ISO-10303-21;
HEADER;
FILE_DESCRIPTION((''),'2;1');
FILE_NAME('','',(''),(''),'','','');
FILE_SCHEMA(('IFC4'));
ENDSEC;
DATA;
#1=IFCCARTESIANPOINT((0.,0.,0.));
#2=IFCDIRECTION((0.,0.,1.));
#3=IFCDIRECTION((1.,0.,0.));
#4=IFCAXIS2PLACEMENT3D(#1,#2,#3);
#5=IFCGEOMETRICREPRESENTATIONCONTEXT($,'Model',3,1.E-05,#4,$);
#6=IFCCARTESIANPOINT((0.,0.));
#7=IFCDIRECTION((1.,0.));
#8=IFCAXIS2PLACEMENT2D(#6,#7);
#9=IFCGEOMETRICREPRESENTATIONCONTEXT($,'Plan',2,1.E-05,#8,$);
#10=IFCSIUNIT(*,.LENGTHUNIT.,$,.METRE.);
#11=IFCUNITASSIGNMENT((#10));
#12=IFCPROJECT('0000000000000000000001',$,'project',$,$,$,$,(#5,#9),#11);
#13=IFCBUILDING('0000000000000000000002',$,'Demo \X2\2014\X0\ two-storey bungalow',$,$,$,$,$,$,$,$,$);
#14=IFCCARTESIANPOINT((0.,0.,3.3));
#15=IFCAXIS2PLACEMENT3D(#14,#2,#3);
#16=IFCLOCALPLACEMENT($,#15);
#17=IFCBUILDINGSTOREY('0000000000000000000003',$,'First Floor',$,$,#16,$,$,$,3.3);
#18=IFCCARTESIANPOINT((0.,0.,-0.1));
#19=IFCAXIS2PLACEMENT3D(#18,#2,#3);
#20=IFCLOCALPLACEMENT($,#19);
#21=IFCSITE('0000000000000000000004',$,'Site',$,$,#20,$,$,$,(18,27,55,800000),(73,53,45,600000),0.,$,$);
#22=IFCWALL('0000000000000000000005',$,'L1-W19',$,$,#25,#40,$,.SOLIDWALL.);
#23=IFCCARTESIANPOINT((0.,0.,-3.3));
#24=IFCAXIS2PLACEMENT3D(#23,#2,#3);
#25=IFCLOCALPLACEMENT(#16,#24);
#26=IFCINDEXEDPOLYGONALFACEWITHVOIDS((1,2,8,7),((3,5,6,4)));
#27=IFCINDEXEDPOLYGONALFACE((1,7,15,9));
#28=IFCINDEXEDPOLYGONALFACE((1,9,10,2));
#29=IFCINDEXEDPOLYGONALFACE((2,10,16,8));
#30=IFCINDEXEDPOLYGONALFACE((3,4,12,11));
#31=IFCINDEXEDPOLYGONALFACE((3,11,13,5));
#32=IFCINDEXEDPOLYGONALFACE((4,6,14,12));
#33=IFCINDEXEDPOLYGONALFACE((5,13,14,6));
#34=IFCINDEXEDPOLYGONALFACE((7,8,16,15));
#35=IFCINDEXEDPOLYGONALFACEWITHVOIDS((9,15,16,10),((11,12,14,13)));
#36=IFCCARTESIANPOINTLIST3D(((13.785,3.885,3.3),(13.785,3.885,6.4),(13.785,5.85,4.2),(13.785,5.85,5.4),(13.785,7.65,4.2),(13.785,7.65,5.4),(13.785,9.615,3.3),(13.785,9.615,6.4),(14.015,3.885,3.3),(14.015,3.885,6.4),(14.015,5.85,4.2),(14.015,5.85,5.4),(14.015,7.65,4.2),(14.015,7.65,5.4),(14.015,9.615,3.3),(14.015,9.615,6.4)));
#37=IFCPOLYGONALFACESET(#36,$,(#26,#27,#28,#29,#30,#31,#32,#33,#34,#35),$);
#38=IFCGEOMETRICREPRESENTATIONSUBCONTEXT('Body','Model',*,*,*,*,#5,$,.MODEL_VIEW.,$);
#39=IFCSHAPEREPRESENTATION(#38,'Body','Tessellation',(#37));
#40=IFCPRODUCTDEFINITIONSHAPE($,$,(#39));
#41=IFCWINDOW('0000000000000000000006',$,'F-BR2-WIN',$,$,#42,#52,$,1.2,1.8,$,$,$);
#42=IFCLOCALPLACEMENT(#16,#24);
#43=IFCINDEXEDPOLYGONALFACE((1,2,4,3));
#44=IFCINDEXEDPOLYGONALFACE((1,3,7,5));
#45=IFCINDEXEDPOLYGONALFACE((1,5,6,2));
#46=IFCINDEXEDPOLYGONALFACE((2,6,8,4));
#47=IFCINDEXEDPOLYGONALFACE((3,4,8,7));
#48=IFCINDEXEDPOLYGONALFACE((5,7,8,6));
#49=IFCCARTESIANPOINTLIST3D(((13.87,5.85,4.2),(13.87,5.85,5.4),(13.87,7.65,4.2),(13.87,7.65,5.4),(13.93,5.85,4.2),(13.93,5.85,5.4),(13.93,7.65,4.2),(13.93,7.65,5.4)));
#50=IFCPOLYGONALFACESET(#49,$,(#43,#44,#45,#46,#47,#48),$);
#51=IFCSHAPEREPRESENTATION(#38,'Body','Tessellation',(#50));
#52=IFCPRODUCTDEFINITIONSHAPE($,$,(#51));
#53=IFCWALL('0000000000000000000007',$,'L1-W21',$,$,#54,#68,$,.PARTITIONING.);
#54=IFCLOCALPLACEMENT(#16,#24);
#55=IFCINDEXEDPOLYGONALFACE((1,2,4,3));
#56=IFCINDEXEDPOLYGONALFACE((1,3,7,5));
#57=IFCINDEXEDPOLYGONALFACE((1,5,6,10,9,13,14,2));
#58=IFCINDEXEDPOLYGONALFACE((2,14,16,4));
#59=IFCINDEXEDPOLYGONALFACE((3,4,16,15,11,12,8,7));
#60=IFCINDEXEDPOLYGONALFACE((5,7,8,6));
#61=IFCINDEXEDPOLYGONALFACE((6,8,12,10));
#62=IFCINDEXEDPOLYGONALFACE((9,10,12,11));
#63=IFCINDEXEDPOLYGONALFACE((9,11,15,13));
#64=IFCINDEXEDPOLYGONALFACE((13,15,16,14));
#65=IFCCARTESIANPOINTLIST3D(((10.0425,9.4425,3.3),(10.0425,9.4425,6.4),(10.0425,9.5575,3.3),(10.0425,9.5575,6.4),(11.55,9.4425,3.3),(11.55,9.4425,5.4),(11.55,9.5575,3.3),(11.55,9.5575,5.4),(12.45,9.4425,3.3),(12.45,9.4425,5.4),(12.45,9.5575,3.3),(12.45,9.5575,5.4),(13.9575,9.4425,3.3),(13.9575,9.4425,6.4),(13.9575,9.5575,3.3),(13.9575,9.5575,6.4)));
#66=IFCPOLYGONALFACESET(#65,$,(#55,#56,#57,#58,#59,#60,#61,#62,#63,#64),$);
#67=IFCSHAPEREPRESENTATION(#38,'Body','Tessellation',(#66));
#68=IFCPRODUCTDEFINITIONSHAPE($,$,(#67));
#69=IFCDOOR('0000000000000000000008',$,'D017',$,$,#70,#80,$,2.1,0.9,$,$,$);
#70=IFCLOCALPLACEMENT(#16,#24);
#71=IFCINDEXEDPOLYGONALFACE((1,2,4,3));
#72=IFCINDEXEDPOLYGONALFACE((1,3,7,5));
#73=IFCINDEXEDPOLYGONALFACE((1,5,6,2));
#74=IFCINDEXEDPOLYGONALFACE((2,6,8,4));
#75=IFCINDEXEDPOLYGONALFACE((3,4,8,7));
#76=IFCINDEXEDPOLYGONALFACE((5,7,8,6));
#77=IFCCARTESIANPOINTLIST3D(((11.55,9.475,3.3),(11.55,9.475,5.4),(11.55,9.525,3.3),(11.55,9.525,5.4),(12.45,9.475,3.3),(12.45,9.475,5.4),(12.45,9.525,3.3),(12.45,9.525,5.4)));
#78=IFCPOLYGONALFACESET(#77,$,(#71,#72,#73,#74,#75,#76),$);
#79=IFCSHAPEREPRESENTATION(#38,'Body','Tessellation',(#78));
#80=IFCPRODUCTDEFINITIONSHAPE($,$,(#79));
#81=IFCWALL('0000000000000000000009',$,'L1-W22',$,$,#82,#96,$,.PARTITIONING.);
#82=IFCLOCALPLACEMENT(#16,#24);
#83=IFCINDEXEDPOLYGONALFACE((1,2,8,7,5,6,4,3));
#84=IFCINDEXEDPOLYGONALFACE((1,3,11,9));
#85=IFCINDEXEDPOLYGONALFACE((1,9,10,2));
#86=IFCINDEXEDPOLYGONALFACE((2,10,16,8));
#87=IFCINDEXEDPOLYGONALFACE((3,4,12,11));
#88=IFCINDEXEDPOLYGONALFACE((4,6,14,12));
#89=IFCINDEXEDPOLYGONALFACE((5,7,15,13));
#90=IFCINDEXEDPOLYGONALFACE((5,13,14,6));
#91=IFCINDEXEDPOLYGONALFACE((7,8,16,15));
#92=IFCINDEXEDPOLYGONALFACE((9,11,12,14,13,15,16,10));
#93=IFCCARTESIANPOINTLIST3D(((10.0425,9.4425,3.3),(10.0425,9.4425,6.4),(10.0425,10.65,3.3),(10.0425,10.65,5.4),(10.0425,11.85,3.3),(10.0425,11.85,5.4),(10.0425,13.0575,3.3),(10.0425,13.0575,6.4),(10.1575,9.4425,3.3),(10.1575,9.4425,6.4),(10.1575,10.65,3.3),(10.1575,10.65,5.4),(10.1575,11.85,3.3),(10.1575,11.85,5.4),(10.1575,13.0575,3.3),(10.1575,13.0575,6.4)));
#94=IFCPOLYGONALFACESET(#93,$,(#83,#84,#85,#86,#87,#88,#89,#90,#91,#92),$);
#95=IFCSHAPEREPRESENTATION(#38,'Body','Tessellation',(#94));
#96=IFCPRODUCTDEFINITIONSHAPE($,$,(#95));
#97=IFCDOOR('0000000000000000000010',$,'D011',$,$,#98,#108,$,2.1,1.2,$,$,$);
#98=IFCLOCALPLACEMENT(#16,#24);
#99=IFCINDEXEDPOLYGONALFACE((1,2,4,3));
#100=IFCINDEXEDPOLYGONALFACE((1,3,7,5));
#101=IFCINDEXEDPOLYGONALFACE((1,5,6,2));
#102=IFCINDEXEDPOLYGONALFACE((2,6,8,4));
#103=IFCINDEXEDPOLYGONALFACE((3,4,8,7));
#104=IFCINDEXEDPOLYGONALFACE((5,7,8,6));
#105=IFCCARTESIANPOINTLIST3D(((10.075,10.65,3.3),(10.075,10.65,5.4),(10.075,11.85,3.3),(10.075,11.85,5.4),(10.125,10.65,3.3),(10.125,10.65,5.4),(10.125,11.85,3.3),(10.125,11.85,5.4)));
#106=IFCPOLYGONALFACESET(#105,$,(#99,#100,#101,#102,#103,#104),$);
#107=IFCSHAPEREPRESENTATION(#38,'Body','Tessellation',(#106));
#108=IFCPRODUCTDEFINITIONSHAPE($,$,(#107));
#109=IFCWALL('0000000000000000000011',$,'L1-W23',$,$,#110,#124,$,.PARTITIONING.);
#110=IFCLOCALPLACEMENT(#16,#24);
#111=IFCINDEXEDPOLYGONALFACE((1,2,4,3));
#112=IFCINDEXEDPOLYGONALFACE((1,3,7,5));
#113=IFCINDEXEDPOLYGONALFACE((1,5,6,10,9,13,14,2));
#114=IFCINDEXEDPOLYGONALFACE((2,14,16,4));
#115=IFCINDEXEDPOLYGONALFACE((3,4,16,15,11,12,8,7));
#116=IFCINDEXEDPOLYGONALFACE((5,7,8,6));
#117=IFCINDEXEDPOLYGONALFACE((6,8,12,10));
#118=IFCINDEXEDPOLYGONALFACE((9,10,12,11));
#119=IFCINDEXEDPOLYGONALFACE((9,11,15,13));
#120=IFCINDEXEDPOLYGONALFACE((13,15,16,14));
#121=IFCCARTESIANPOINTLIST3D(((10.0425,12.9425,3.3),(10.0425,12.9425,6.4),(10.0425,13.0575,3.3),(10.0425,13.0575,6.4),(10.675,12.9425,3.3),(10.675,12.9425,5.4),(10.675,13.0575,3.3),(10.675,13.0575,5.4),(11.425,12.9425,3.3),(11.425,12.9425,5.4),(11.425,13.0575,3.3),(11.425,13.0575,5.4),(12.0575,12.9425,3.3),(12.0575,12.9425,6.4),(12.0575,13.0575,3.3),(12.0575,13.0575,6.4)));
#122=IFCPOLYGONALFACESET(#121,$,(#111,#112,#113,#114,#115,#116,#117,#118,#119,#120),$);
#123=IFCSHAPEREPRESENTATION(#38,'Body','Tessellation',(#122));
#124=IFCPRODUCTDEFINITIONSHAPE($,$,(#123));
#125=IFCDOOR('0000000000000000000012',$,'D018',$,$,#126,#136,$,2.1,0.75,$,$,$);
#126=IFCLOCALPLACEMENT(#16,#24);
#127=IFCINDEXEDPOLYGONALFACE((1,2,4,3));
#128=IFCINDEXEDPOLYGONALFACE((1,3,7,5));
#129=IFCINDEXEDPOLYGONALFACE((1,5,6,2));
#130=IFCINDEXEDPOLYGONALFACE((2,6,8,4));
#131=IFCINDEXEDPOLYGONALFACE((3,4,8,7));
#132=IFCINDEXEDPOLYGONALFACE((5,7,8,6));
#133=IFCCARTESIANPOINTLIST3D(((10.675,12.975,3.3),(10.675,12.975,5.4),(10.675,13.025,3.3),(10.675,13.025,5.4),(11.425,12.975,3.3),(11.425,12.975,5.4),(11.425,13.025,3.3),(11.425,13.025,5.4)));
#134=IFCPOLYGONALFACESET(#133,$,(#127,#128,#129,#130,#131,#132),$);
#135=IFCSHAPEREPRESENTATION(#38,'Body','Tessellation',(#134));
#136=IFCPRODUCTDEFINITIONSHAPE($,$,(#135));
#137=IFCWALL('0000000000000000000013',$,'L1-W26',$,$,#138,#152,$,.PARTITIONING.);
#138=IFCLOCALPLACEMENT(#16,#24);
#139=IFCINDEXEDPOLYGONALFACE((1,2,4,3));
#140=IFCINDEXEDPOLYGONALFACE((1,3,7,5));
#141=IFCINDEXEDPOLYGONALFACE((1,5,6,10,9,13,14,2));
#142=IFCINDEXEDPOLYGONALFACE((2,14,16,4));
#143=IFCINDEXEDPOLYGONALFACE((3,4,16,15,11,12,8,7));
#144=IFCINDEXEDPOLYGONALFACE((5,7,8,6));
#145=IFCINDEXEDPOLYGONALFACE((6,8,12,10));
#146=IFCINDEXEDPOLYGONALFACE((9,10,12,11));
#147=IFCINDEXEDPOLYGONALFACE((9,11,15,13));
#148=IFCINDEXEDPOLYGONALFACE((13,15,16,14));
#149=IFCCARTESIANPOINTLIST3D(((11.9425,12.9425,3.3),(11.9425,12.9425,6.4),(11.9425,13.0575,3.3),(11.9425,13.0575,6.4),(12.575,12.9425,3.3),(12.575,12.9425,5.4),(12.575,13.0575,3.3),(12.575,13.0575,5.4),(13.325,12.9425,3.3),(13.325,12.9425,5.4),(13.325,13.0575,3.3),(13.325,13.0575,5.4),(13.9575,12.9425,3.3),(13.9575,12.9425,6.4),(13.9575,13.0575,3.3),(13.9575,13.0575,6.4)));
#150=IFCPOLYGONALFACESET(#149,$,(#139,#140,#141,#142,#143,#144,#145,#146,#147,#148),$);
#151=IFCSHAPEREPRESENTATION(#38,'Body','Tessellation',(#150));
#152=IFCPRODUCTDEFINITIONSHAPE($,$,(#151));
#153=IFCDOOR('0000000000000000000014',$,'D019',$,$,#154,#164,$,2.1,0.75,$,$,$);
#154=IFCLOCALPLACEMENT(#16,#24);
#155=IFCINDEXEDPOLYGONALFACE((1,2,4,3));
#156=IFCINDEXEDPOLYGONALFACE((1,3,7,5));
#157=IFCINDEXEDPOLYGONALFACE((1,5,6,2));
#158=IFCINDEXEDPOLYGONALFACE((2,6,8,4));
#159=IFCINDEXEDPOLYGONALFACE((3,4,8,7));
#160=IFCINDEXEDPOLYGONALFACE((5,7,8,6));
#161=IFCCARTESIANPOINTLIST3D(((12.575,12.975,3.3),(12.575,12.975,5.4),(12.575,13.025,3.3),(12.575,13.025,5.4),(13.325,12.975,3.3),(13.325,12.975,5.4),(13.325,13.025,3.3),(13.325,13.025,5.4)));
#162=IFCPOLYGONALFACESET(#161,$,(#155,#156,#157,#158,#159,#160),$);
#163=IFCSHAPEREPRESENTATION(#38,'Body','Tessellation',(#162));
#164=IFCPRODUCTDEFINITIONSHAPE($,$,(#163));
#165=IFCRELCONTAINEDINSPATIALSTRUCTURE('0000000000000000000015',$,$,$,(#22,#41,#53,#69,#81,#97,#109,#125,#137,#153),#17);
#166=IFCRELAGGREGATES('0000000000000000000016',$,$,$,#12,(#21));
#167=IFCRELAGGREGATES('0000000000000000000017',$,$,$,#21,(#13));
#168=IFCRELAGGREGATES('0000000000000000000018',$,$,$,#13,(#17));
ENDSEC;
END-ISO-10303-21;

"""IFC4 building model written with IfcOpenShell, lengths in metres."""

from ifc_helpers import new_model, si_unit, frame, origin_with_axes, origin_2d_with_axis, place, context, subcontext, project, spatial, line, indexed_curve, outline, extrude, element, fill, save


model = new_model("IFC4")

# Units and contexts
model_context = context("Model", 3, precision=1e-05, world=origin_with_axes())
plan_context = context("Plan", 2, precision=1e-05, world=origin_2d_with_axis())
body_context = subcontext(model_context, "Body", "Model", "MODEL_VIEW")
ifc_project = project(units=[si_unit("LENGTHUNIT", "METRE")], contexts=[model_context, plan_context])

# Site, building, storey
site_placement = place(None, frame((0.0, 0.0, -0.1), z_axis=(0.0, 0.0, 1.0), x_axis=(1.0, 0.0, 0.0)))
site = spatial("IfcSite", under=ifc_project, at=site_placement, Name="Site", RefLatitude=(18, 27, 55, 800000), RefLongitude=(73, 53, 45, 600000), RefElevation=0.0)
building = spatial("IfcBuilding", under=site, Name="Demo — two-storey bungalow")
storey_placement = place(None, frame((0.0, 0.0, 3.3), z_axis=(0.0, 0.0, 1.0), x_axis=(1.0, 0.0, 0.0)))
storey = spatial("IfcBuildingStorey", under=building, at=storey_placement, Name="First Floor", Elevation=3.3)

# Wall, opening, window
wall_1_placement = place(storey_placement, frame((0.0, 0.0, -3.3), z_axis=(0.0, 0.0, 1.0), x_axis=(1.0, 0.0, 0.0)))
wall_1 = element("IfcWall", 1, at=wall_1_placement, inside=storey, Name="L1-W19", PredefinedType="SOLIDWALL", context=body_context, shape_type="SweptSolid", body=[
    extrude(outline(indexed_curve([(13.785, 3.885), (13.785, 9.615), (14.015, 9.615), (14.015, 3.885)], segments=[line(1, 2, 3, 4, 1)])), frame((0.0, 0.0, 3.3), z_axis=(0.0, 0.0, 1.0), x_axis=(1.0, 0.0, 0.0)), (0.0, 0.0, 1.0), 3.1),
])
opening_1_placement = place(wall_1_placement, origin_with_axes())
opening_1 = element("IfcOpeningElement", 2, at=opening_1_placement, cuts=wall_1, context=body_context, shape_type="SweptSolid", body=[
    extrude(outline(indexed_curve([(13.735, 5.85), (13.735, 7.65), (14.065, 7.65), (14.065, 5.85)], segments=[line(1, 2, 3, 4, 1)])), frame((0.0, 0.0, 4.2), z_axis=(0.0, 0.0, 1.0), x_axis=(1.0, 0.0, 0.0)), (0.0, 0.0, 1.0), 1.2),
])
window_1_placement = place(storey_placement, frame((0.0, 0.0, -3.3), z_axis=(0.0, 0.0, 1.0), x_axis=(1.0, 0.0, 0.0)))
window_1 = element("IfcWindow", 3, at=window_1_placement, inside=storey, Name="F-BR2-WIN", OverallHeight=1.2, OverallWidth=1.8, context=body_context, shape_type="SweptSolid", body=[
    extrude(outline(indexed_curve([(13.87, 5.85), (13.87, 7.65), (13.93, 7.65), (13.93, 5.85)], segments=[line(1, 2, 3, 4, 1)])), frame((0.0, 0.0, 4.2), z_axis=(0.0, 0.0, 1.0), x_axis=(1.0, 0.0, 0.0)), (0.0, 0.0, 1.0), 1.2),
])
fill(opening_1, window_1)

# Walls, openings, doors
wall_2_placement = place(storey_placement, frame((0.0, 0.0, -3.3), z_axis=(0.0, 0.0, 1.0), x_axis=(1.0, 0.0, 0.0)))
wall_2 = element("IfcWall", 4, at=wall_2_placement, inside=storey, Name="L1-W21", PredefinedType="PARTITIONING", context=body_context, shape_type="SweptSolid", body=[
    extrude(outline(indexed_curve([(13.9575, 9.4425), (10.0425, 9.4425), (10.0425, 9.5575), (13.9575, 9.5575)], segments=[line(1, 2, 3, 4, 1)])), frame((0.0, 0.0, 3.3), z_axis=(0.0, 0.0, 1.0), x_axis=(1.0, 0.0, 0.0)), (0.0, 0.0, 1.0), 3.1),
])
opening_2_placement = place(wall_2_placement, origin_with_axes())
opening_2 = element("IfcOpeningElement", 5, at=opening_2_placement, cuts=wall_2, context=body_context, shape_type="SweptSolid", body=[
    extrude(outline(indexed_curve([(12.45, 9.3925), (11.55, 9.3925), (11.55, 9.6075), (12.45, 9.6075)], segments=[line(1, 2, 3, 4, 1)])), frame((0.0, 0.0, 3.3), z_axis=(0.0, 0.0, 1.0), x_axis=(1.0, 0.0, 0.0)), (0.0, 0.0, 1.0), 2.1),
])
door_1_placement = place(storey_placement, frame((0.0, 0.0, -3.3), z_axis=(0.0, 0.0, 1.0), x_axis=(1.0, 0.0, 0.0)))
door_1 = element("IfcDoor", 6, at=door_1_placement, inside=storey, Name="D017", OverallHeight=2.1, OverallWidth=0.9, context=body_context, shape_type="SweptSolid", body=[
    extrude(outline(indexed_curve([(12.45, 9.475), (11.55, 9.475), (11.55, 9.525), (12.45, 9.525)], segments=[line(1, 2, 3, 4, 1)])), frame((0.0, 0.0, 3.3), z_axis=(0.0, 0.0, 1.0), x_axis=(1.0, 0.0, 0.0)), (0.0, 0.0, 1.0), 2.1),
])
fill(opening_2, door_1)
wall_3_placement = place(storey_placement, frame((0.0, 0.0, -3.3), z_axis=(0.0, 0.0, 1.0), x_axis=(1.0, 0.0, 0.0)))
wall_3 = element("IfcWall", 7, at=wall_3_placement, inside=storey, Name="L1-W22", PredefinedType="PARTITIONING", context=body_context, shape_type="SweptSolid", body=[
    extrude(outline(indexed_curve([(10.0425, 9.4425), (10.0425, 13.0575), (10.1575, 13.0575), (10.1575, 9.4425)], segments=[line(1, 2, 3, 4, 1)])), frame((0.0, 0.0, 3.3), z_axis=(0.0, 0.0, 1.0), x_axis=(1.0, 0.0, 0.0)), (0.0, 0.0, 1.0), 3.1),
])
opening_3_placement = place(wall_3_placement, origin_with_axes())
opening_3 = element("IfcOpeningElement", 8, at=opening_3_placement, cuts=wall_3, context=body_context, shape_type="SweptSolid", body=[
    extrude(outline(indexed_curve([(9.9925, 10.65), (9.9925, 11.85), (10.2075, 11.85), (10.2075, 10.65)], segments=[line(1, 2, 3, 4, 1)])), frame((0.0, 0.0, 3.3), z_axis=(0.0, 0.0, 1.0), x_axis=(1.0, 0.0, 0.0)), (0.0, 0.0, 1.0), 2.1),
])
door_2_placement = place(storey_placement, frame((0.0, 0.0, -3.3), z_axis=(0.0, 0.0, 1.0), x_axis=(1.0, 0.0, 0.0)))
door_2 = element("IfcDoor", 9, at=door_2_placement, inside=storey, Name="D011", OverallHeight=2.1, OverallWidth=1.2, context=body_context, shape_type="SweptSolid", body=[
    extrude(outline(indexed_curve([(10.075, 10.65), (10.075, 11.85), (10.125, 11.85), (10.125, 10.65)], segments=[line(1, 2, 3, 4, 1)])), frame((0.0, 0.0, 3.3), z_axis=(0.0, 0.0, 1.0), x_axis=(1.0, 0.0, 0.0)), (0.0, 0.0, 1.0), 2.1),
])
fill(opening_3, door_2)
wall_4_placement = place(storey_placement, frame((0.0, 0.0, -3.3), z_axis=(0.0, 0.0, 1.0), x_axis=(1.0, 0.0, 0.0)))
wall_4 = element("IfcWall", 10, at=wall_4_placement, inside=storey, Name="L1-W23", PredefinedType="PARTITIONING", context=body_context, shape_type="SweptSolid", body=[
    extrude(outline(indexed_curve([(12.0575, 12.9425), (10.0425, 12.9425), (10.0425, 13.0575), (12.0575, 13.0575)], segments=[line(1, 2, 3, 4, 1)])), frame((0.0, 0.0, 3.3), z_axis=(0.0, 0.0, 1.0), x_axis=(1.0, 0.0, 0.0)), (0.0, 0.0, 1.0), 3.1),
])
opening_4_placement = place(wall_4_placement, origin_with_axes())
opening_4 = element("IfcOpeningElement", 11, at=opening_4_placement, cuts=wall_4, context=body_context, shape_type="SweptSolid", body=[
    extrude(outline(indexed_curve([(11.425, 12.8925), (10.675, 12.8925), (10.675, 13.1075), (11.425, 13.1075)], segments=[line(1, 2, 3, 4, 1)])), frame((0.0, 0.0, 3.3), z_axis=(0.0, 0.0, 1.0), x_axis=(1.0, 0.0, 0.0)), (0.0, 0.0, 1.0), 2.1),
])
door_3_placement = place(storey_placement, frame((0.0, 0.0, -3.3), z_axis=(0.0, 0.0, 1.0), x_axis=(1.0, 0.0, 0.0)))
door_3 = element("IfcDoor", 12, at=door_3_placement, inside=storey, Name="D018", OverallHeight=2.1, OverallWidth=0.75, context=body_context, shape_type="SweptSolid", body=[
    extrude(outline(indexed_curve([(11.425, 12.975), (10.675, 12.975), (10.675, 13.025), (11.425, 13.025)], segments=[line(1, 2, 3, 4, 1)])), frame((0.0, 0.0, 3.3), z_axis=(0.0, 0.0, 1.0), x_axis=(1.0, 0.0, 0.0)), (0.0, 0.0, 1.0), 2.1),
])
fill(opening_4, door_3)

# Wall, opening, door
wall_5_placement = place(storey_placement, frame((0.0, 0.0, -3.3), z_axis=(0.0, 0.0, 1.0), x_axis=(1.0, 0.0, 0.0)))
wall_5 = element("IfcWall", 13, at=wall_5_placement, inside=storey, Name="L1-W26", PredefinedType="PARTITIONING", context=body_context, shape_type="SweptSolid", body=[
    extrude(outline(indexed_curve([(13.9575, 12.9425), (11.9425, 12.9425), (11.9425, 13.0575), (13.9575, 13.0575)], segments=[line(1, 2, 3, 4, 1)])), frame((0.0, 0.0, 3.3), z_axis=(0.0, 0.0, 1.0), x_axis=(1.0, 0.0, 0.0)), (0.0, 0.0, 1.0), 3.1),
])
opening_5_placement = place(wall_5_placement, origin_with_axes())
opening_5 = element("IfcOpeningElement", 14, at=opening_5_placement, cuts=wall_5, context=body_context, shape_type="SweptSolid", body=[
    extrude(outline(indexed_curve([(13.325, 12.8925), (12.575, 12.8925), (12.575, 13.1075), (13.325, 13.1075)], segments=[line(1, 2, 3, 4, 1)])), frame((0.0, 0.0, 3.3), z_axis=(0.0, 0.0, 1.0), x_axis=(1.0, 0.0, 0.0)), (0.0, 0.0, 1.0), 2.1),
])
door_4_placement = place(storey_placement, frame((0.0, 0.0, -3.3), z_axis=(0.0, 0.0, 1.0), x_axis=(1.0, 0.0, 0.0)))
door_4 = element("IfcDoor", 15, at=door_4_placement, inside=storey, Name="D019", OverallHeight=2.1, OverallWidth=0.75, context=body_context, shape_type="SweptSolid", body=[
    extrude(outline(indexed_curve([(13.325, 12.975), (12.575, 12.975), (12.575, 13.025), (13.325, 13.025)], segments=[line(1, 2, 3, 4, 1)])), frame((0.0, 0.0, 3.3), z_axis=(0.0, 0.0, 1.0), x_axis=(1.0, 0.0, 0.0)), (0.0, 0.0, 1.0), 2.1),
])
fill(opening_5, door_4)

save(model, "model.ifc")
